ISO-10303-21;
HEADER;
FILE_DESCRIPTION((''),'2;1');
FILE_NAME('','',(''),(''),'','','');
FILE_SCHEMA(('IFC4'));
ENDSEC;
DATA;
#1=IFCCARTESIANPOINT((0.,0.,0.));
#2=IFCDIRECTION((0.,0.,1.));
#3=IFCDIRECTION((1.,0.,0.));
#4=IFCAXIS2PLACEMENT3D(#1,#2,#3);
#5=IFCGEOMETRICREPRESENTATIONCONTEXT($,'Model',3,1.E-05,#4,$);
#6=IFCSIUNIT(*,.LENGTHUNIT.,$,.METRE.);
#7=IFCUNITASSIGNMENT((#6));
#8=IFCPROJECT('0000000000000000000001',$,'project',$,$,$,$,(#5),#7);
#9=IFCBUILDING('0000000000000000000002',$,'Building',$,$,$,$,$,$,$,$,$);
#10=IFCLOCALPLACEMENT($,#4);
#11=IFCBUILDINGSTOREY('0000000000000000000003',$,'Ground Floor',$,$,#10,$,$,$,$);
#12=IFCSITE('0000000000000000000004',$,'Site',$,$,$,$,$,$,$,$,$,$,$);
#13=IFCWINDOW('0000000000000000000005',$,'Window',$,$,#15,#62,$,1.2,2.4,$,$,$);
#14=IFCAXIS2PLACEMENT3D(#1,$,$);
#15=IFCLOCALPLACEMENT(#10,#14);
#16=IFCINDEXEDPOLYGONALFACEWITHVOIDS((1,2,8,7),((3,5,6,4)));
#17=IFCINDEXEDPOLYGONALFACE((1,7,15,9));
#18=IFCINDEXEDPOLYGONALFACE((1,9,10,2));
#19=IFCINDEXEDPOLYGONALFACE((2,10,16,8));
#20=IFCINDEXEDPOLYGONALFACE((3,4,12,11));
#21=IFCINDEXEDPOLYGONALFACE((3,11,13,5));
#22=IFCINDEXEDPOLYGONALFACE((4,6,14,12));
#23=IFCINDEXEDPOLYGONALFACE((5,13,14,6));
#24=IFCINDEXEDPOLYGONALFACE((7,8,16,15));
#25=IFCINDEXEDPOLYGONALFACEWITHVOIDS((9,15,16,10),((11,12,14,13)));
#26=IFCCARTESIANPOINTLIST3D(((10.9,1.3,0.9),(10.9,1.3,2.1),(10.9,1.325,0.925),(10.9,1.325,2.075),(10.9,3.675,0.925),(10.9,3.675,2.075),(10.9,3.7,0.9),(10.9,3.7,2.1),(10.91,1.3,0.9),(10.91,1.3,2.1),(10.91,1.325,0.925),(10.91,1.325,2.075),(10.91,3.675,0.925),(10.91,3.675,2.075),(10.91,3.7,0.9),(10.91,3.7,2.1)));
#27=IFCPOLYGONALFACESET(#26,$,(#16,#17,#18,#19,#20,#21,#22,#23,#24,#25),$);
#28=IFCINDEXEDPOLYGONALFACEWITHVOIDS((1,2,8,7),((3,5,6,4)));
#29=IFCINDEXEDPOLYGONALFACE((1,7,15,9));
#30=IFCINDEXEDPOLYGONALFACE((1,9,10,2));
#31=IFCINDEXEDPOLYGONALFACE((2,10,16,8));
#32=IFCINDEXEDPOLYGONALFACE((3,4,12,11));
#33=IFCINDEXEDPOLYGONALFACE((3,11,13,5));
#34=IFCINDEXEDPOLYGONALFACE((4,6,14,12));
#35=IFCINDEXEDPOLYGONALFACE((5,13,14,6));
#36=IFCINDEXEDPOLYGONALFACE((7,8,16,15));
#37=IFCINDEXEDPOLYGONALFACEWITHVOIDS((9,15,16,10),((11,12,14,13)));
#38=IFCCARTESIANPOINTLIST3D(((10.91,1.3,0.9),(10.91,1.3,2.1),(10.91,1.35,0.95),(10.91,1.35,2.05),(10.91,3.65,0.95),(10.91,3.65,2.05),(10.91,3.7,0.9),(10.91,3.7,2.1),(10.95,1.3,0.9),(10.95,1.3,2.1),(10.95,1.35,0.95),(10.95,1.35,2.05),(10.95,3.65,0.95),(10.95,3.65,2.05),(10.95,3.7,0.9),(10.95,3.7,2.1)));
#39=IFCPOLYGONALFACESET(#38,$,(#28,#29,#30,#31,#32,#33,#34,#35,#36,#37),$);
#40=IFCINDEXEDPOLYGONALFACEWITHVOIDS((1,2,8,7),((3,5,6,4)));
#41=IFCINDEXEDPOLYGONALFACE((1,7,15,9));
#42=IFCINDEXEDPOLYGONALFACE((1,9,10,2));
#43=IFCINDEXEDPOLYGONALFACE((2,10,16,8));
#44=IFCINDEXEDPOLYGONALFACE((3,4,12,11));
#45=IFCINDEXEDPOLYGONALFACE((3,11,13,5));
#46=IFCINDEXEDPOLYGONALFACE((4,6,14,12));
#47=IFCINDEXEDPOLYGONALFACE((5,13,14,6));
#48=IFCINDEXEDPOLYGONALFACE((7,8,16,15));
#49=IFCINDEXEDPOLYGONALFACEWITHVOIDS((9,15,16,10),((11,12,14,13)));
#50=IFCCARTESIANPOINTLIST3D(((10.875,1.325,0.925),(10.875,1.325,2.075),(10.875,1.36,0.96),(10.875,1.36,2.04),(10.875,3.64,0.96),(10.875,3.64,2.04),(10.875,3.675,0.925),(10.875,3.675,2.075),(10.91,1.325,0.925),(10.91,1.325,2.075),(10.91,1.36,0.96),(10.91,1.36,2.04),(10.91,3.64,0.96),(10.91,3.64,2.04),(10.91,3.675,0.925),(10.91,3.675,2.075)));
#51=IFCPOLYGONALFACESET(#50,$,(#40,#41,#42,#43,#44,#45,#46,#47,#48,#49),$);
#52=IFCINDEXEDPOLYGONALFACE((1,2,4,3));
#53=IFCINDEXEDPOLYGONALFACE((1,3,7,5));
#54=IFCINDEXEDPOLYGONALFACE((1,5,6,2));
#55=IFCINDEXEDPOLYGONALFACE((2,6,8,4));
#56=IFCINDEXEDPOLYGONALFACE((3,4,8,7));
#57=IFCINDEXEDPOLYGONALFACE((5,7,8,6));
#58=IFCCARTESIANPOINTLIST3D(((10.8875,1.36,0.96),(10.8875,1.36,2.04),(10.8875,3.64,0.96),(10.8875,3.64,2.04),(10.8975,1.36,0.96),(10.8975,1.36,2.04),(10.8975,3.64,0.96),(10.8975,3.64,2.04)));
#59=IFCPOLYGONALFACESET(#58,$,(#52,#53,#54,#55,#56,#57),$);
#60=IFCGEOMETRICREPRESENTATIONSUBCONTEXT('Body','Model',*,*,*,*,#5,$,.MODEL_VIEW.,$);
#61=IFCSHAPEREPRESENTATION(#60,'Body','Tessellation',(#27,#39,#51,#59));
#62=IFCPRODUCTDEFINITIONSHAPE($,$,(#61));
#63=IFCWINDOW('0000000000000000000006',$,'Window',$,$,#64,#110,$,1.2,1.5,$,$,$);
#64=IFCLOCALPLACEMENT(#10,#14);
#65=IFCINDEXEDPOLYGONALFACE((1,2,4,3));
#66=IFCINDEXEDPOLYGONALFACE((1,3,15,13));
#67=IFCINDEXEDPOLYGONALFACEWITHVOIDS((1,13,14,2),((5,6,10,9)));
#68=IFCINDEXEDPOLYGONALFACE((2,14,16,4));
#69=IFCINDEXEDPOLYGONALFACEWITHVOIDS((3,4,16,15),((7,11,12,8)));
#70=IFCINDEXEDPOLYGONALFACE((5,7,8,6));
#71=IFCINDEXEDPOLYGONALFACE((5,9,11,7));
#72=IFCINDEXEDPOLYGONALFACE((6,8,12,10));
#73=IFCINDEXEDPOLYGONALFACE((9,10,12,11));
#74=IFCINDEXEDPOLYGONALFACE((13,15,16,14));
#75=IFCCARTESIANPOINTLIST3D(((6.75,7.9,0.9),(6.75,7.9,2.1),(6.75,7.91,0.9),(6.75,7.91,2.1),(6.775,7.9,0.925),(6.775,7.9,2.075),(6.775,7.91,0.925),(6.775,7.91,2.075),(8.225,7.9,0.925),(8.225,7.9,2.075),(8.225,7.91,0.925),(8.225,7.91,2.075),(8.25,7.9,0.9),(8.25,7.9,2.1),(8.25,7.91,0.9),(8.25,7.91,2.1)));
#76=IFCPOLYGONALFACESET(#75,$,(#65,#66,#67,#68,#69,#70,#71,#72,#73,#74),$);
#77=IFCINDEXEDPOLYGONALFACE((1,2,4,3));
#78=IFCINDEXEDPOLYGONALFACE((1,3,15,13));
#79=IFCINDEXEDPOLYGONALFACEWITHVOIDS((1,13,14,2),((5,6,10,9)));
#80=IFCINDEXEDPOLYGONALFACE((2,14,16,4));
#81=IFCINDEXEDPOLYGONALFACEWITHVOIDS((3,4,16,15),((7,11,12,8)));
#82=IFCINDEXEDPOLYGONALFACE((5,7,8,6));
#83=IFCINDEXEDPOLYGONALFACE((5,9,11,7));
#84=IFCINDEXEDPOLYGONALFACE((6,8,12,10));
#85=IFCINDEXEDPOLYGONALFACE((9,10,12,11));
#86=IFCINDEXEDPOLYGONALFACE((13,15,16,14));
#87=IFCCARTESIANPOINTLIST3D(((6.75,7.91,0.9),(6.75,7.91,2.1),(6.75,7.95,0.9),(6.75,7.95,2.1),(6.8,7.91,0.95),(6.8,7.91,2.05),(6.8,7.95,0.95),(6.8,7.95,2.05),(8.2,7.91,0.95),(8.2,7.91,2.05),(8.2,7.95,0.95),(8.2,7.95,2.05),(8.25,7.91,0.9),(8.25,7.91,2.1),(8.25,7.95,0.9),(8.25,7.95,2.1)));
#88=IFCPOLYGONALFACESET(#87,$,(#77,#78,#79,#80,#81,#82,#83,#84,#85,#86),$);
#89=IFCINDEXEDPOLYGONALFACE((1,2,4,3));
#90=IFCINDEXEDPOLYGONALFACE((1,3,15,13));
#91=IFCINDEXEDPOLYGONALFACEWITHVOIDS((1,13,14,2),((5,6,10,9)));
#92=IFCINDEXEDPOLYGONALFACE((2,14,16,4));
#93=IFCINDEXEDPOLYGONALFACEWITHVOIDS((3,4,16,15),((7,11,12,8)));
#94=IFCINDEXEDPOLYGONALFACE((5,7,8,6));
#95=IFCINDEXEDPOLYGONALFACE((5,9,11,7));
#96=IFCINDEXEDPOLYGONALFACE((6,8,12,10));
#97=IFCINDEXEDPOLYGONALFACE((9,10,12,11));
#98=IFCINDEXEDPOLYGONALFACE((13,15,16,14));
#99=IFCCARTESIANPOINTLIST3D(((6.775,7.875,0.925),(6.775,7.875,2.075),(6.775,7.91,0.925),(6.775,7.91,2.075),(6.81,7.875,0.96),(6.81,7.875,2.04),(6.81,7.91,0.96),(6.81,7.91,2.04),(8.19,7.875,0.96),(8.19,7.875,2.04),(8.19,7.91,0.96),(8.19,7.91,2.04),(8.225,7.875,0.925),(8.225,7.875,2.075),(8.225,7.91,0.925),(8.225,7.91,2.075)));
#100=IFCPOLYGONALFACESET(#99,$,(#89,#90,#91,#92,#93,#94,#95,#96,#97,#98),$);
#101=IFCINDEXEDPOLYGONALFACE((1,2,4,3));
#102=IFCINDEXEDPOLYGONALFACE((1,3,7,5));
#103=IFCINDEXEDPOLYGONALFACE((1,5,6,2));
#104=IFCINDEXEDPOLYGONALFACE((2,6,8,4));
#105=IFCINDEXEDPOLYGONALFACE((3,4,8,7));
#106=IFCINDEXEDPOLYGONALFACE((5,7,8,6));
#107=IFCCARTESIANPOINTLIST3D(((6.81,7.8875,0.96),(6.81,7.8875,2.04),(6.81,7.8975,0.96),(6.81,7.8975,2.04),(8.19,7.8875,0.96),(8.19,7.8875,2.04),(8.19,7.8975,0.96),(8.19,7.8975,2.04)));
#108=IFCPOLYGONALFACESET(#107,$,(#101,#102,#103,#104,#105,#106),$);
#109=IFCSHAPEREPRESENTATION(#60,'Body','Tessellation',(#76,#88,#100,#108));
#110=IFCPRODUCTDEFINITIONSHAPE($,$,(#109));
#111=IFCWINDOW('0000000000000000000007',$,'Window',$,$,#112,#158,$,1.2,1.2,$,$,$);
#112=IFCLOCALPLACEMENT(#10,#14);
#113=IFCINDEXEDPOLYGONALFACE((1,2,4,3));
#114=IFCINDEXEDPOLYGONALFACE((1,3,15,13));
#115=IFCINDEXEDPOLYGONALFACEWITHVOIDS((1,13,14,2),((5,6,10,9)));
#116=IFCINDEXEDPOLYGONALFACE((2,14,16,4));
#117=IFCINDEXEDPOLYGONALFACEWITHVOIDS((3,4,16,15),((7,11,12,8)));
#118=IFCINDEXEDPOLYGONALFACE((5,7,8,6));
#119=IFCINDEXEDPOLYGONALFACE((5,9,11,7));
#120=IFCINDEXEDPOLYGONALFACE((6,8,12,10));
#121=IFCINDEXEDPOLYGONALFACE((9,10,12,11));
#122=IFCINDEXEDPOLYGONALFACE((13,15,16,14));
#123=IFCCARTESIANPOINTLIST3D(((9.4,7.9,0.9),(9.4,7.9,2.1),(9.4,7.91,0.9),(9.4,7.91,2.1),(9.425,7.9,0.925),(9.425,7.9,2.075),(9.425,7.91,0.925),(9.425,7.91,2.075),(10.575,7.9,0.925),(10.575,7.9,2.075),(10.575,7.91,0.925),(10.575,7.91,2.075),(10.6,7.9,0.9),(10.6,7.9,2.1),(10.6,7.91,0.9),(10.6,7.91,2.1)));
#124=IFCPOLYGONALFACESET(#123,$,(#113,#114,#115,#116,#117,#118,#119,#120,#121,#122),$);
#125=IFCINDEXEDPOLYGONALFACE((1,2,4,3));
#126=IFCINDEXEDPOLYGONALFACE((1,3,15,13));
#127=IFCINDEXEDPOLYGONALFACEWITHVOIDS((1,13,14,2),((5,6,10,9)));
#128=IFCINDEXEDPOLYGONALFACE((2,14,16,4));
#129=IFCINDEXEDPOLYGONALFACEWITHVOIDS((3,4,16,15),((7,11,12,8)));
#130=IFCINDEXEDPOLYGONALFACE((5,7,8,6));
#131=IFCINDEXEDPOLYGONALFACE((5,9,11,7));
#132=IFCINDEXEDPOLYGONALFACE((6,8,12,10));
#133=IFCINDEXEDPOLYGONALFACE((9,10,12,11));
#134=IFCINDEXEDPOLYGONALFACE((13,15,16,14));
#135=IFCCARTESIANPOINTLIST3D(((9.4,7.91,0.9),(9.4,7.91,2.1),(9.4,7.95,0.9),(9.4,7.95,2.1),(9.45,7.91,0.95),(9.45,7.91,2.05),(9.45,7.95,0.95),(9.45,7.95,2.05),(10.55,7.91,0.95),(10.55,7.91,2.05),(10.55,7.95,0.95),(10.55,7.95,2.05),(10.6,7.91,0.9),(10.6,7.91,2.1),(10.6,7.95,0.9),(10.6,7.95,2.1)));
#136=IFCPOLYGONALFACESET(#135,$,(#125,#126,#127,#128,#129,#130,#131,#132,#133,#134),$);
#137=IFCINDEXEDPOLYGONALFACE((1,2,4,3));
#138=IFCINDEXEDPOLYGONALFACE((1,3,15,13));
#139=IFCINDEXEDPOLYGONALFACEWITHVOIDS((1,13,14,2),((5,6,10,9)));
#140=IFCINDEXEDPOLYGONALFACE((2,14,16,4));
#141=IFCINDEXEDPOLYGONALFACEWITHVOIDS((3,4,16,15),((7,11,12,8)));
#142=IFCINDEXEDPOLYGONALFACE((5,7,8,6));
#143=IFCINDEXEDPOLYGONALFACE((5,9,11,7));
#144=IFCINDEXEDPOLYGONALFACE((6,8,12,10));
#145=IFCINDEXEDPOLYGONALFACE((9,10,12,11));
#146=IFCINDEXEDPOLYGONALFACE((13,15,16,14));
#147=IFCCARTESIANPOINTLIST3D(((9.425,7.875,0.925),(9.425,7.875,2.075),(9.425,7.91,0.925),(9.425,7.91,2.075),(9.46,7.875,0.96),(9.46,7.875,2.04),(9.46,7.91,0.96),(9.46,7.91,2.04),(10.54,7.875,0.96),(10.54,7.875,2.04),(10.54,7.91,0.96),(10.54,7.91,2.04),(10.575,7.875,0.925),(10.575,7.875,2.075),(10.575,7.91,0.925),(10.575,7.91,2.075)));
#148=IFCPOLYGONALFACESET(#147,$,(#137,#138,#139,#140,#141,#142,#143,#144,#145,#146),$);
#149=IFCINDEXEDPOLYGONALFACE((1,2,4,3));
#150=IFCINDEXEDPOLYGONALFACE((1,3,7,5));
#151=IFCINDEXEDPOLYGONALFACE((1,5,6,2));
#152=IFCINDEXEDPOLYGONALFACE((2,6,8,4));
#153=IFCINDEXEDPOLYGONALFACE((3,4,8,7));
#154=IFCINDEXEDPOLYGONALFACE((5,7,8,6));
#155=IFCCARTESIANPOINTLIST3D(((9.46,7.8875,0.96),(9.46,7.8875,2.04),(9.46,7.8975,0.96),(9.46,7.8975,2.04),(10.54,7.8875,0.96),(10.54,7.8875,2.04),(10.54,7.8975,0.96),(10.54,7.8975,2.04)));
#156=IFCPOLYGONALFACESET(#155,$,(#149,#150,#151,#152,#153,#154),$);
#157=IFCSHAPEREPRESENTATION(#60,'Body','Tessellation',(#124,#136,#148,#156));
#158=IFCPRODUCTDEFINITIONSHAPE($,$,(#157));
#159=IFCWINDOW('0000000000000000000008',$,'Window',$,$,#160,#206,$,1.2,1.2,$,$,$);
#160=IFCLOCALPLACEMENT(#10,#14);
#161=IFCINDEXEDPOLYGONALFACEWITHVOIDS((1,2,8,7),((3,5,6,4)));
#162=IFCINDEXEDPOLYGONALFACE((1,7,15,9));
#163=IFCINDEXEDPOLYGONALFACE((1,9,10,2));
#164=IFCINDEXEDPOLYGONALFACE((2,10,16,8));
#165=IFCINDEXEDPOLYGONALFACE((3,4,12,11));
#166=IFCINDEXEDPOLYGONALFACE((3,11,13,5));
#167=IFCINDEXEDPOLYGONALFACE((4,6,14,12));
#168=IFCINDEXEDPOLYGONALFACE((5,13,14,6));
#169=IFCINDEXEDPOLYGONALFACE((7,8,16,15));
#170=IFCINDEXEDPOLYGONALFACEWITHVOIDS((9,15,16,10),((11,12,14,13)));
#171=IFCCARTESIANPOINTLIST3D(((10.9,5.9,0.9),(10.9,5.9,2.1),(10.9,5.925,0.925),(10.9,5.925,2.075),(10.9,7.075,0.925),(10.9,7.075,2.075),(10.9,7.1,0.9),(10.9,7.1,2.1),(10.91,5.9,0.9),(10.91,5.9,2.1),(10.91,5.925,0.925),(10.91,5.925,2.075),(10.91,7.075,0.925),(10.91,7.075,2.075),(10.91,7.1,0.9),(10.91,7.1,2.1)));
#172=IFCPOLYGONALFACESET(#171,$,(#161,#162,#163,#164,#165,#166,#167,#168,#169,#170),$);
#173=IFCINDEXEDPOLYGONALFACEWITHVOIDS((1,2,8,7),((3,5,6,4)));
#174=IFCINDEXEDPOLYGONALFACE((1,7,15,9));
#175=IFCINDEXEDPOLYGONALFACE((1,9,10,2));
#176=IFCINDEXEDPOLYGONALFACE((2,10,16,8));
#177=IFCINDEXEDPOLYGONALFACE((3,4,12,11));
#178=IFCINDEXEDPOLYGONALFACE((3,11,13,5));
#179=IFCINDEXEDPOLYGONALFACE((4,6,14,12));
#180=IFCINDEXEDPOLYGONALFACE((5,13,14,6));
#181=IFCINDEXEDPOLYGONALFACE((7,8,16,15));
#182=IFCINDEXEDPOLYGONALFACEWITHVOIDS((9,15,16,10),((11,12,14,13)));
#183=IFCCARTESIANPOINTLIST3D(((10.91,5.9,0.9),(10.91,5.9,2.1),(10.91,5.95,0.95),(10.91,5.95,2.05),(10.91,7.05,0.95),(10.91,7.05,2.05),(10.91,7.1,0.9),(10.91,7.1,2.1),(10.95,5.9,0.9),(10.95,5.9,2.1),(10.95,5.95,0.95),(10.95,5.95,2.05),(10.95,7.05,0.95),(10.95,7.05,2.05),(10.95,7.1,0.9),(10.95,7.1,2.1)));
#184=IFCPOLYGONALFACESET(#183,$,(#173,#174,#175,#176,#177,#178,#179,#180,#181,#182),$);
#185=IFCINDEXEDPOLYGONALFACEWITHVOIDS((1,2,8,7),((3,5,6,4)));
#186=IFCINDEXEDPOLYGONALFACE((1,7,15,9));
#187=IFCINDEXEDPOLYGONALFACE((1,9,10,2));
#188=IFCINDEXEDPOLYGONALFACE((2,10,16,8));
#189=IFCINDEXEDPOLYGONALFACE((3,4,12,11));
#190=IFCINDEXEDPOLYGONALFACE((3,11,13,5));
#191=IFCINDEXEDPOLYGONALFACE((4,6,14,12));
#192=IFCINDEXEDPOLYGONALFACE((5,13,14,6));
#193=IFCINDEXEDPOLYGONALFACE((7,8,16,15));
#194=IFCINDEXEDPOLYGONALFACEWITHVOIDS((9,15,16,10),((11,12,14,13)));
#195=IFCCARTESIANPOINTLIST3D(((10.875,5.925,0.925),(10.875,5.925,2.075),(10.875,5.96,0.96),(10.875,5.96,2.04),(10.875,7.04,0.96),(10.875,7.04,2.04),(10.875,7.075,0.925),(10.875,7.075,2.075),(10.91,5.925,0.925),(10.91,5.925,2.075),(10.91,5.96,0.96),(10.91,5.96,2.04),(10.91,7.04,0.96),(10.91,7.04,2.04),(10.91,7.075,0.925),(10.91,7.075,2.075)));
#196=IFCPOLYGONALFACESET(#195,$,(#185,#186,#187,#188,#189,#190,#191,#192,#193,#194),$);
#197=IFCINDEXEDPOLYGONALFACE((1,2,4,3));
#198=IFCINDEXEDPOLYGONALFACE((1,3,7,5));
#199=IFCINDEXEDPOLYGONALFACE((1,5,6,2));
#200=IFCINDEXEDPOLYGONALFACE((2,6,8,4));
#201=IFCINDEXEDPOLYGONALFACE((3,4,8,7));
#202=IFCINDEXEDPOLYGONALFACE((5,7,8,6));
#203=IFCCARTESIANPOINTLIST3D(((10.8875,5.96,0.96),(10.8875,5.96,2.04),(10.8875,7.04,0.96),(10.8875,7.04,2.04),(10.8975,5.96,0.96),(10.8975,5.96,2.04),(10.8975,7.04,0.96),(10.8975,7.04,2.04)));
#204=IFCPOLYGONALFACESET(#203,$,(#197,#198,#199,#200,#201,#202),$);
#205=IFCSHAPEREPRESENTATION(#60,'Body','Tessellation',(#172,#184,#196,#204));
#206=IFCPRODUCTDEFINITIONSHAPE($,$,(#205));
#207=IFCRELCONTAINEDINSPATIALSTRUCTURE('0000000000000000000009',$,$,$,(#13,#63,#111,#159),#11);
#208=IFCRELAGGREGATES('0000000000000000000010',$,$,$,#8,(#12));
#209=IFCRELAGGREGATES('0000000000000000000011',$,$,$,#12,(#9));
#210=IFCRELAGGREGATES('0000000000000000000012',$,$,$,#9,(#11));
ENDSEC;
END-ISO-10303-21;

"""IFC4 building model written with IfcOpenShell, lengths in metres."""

from ifc_helpers import new_model, si_unit, frame, origin_with_axes, place, context, subcontext, project, spatial, line, indexed_curve, outline, extrude, element, save


model = new_model("IFC4")

# Units and contexts
model_context = context("Model", 3, precision=1e-05, world=origin_with_axes())
body_context = subcontext(model_context, "Body", "Model", "MODEL_VIEW")
ifc_project = project(units=[si_unit("LENGTHUNIT", "METRE")], contexts=[model_context])

# Site, building, storey
site = spatial("IfcSite", under=ifc_project, Name="Site")
building = spatial("IfcBuilding", under=site, Name="Building")
storey_placement = place(None, origin_with_axes())
storey = spatial("IfcBuildingStorey", under=building, at=storey_placement, Name="Ground Floor")

# Windows
window_1_placement = place(storey_placement, frame((11.0, 1.3, 0.9), z_axis=(0.0, 0.0, 1.0), x_axis=(0.0, 1.0, 0.0)))
element("IfcWindow", 1, at=window_1_placement, inside=storey, Name="Window", OverallHeight=1.2, OverallWidth=2.4, context=body_context, shape_type="SweptSolid", body=[
    extrude(outline(indexed_curve([(0.0, 0.0), (2.4, 0.0), (2.4, 1.2), (0.0, 1.2)], segments=[line(1, 2, 3, 4, 1)]), holes=[indexed_curve([(0.025, 0.025), (2.375, 0.025), (2.375, 1.175), (0.025, 1.175)], segments=[line(1, 2, 3, 4, 1)])]), frame((0.0, 0.09, 0.0), z_axis=(0.0, -1.0, 0.0), x_axis=(1.0, 0.0, 0.0)), (0.0, 0.0, -1.0), 0.01),
    extrude(outline(indexed_curve([(0.0, 0.0), (2.4, 0.0), (2.4, 1.2), (0.0, 1.2)], segments=[line(1, 2, 3, 4, 1)]), holes=[indexed_curve([(0.05, 0.05), (2.35, 0.05), (2.35, 1.15), (0.05, 1.15)], segments=[line(1, 2, 3, 4, 1)])]), frame((0.0, 0.05, 0.0), z_axis=(0.0, -1.0, 0.0), x_axis=(1.0, 0.0, 0.0)), (0.0, 0.0, -1.0), 0.04),
    extrude(outline(indexed_curve([(0.0, 0.0), (2.35, 0.0), (2.35, 1.15), (0.0, 1.15)], segments=[line(1, 2, 3, 4, 1)]), holes=[indexed_curve([(0.035, 0.035), (2.315, 0.035), (2.315, 1.115), (0.035, 1.115)], segments=[line(1, 2, 3, 4, 1)])]), frame((0.025, 0.09, 0.025), z_axis=(0.0, -1.0, 0.0), x_axis=(1.0, 0.0, 0.0)), (0.0, 0.0, -1.0), 0.035),
    extrude(outline(indexed_curve([(0.035, 0.035), (2.315, 0.035), (2.315, 1.115), (0.035, 1.115)], segments=[line(1, 2, 3, 4, 1)])), frame((0.025, 0.1025, 0.025), z_axis=(0.0, -1.0, 0.0), x_axis=(1.0, 0.0, 0.0)), (0.0, 0.0, -1.0), 0.01),
])
window_2_placement = place(storey_placement, frame((8.25, 8.0, 0.9), z_axis=(0.0, 0.0, 1.0), x_axis=(-1.0, 0.0, 0.0)))
element("IfcWindow", 2, at=window_2_placement, inside=storey, Name="Window", OverallHeight=1.2, OverallWidth=1.5, context=body_context, shape_type="SweptSolid", body=[
    extrude(outline(indexed_curve([(0.0, 0.0), (1.5, 0.0), (1.5, 1.2), (0.0, 1.2)], segments=[line(1, 2, 3, 4, 1)]), holes=[indexed_curve([(0.025, 0.025), (1.475, 0.025), (1.475, 1.175), (0.025, 1.175)], segments=[line(1, 2, 3, 4, 1)])]), frame((0.0, 0.09, 0.0), z_axis=(0.0, -1.0, 0.0), x_axis=(1.0, 0.0, 0.0)), (0.0, 0.0, -1.0), 0.01),
    extrude(outline(indexed_curve([(0.0, 0.0), (1.5, 0.0), (1.5, 1.2), (0.0, 1.2)], segments=[line(1, 2, 3, 4, 1)]), holes=[indexed_curve([(0.05, 0.05), (1.45, 0.05), (1.45, 1.15), (0.05, 1.15)], segments=[line(1, 2, 3, 4, 1)])]), frame((0.0, 0.05, 0.0), z_axis=(0.0, -1.0, 0.0), x_axis=(1.0, 0.0, 0.0)), (0.0, 0.0, -1.0), 0.04),
    extrude(outline(indexed_curve([(0.0, 0.0), (1.45, 0.0), (1.45, 1.15), (0.0, 1.15)], segments=[line(1, 2, 3, 4, 1)]), holes=[indexed_curve([(0.035, 0.035), (1.415, 0.035), (1.415, 1.115), (0.035, 1.115)], segments=[line(1, 2, 3, 4, 1)])]), frame((0.025, 0.09, 0.025), z_axis=(0.0, -1.0, 0.0), x_axis=(1.0, 0.0, 0.0)), (0.0, 0.0, -1.0), 0.035),
    extrude(outline(indexed_curve([(0.035, 0.035), (1.415, 0.035), (1.415, 1.115), (0.035, 1.115)], segments=[line(1, 2, 3, 4, 1)])), frame((0.025, 0.1025, 0.025), z_axis=(0.0, -1.0, 0.0), x_axis=(1.0, 0.0, 0.0)), (0.0, 0.0, -1.0), 0.01),
])
for number, where, z_axis, x_axis, name in (
    (3, (10.6, 8.0, 0.9), (0.0, 0.0, 1.0), (-1.0, 0.0, 0.0), "Window"),
    (4, (11.0, 5.9, 0.9), (0.0, 0.0, 1.0), (0.0, 1.0, 0.0), "Window"),
):
    element("IfcWindow", number, at=place(storey_placement, frame(where, z_axis=z_axis, x_axis=x_axis)), inside=storey, Name=name, OverallHeight=1.2, OverallWidth=1.2, context=body_context, shape_type="SweptSolid", body=[
        extrude(outline(indexed_curve([(0.0, 0.0), (1.2, 0.0), (1.2, 1.2), (0.0, 1.2)], segments=[line(1, 2, 3, 4, 1)]), holes=[indexed_curve([(0.025, 0.025), (1.175, 0.025), (1.175, 1.175), (0.025, 1.175)], segments=[line(1, 2, 3, 4, 1)])]), frame((0.0, 0.09, 0.0), z_axis=(0.0, -1.0, 0.0), x_axis=(1.0, 0.0, 0.0)), (0.0, 0.0, -1.0), 0.01),
        extrude(outline(indexed_curve([(0.0, 0.0), (1.2, 0.0), (1.2, 1.2), (0.0, 1.2)], segments=[line(1, 2, 3, 4, 1)]), holes=[indexed_curve([(0.05, 0.05), (1.15, 0.05), (1.15, 1.15), (0.05, 1.15)], segments=[line(1, 2, 3, 4, 1)])]), frame((0.0, 0.05, 0.0), z_axis=(0.0, -1.0, 0.0), x_axis=(1.0, 0.0, 0.0)), (0.0, 0.0, -1.0), 0.04),
        extrude(outline(indexed_curve([(0.0, 0.0), (1.15, 0.0), (1.15, 1.15), (0.0, 1.15)], segments=[line(1, 2, 3, 4, 1)]), holes=[indexed_curve([(0.035, 0.035), (1.115, 0.035), (1.115, 1.115), (0.035, 1.115)], segments=[line(1, 2, 3, 4, 1)])]), frame((0.025, 0.09, 0.025), z_axis=(0.0, -1.0, 0.0), x_axis=(1.0, 0.0, 0.0)), (0.0, 0.0, -1.0), 0.035),
        extrude(outline(indexed_curve([(0.035, 0.035), (1.115, 0.035), (1.115, 1.115), (0.035, 1.115)], segments=[line(1, 2, 3, 4, 1)])), frame((0.025, 0.1025, 0.025), z_axis=(0.0, -1.0, 0.0), x_axis=(1.0, 0.0, 0.0)), (0.0, 0.0, -1.0), 0.01),
    ])

save(model, "model.ifc")
